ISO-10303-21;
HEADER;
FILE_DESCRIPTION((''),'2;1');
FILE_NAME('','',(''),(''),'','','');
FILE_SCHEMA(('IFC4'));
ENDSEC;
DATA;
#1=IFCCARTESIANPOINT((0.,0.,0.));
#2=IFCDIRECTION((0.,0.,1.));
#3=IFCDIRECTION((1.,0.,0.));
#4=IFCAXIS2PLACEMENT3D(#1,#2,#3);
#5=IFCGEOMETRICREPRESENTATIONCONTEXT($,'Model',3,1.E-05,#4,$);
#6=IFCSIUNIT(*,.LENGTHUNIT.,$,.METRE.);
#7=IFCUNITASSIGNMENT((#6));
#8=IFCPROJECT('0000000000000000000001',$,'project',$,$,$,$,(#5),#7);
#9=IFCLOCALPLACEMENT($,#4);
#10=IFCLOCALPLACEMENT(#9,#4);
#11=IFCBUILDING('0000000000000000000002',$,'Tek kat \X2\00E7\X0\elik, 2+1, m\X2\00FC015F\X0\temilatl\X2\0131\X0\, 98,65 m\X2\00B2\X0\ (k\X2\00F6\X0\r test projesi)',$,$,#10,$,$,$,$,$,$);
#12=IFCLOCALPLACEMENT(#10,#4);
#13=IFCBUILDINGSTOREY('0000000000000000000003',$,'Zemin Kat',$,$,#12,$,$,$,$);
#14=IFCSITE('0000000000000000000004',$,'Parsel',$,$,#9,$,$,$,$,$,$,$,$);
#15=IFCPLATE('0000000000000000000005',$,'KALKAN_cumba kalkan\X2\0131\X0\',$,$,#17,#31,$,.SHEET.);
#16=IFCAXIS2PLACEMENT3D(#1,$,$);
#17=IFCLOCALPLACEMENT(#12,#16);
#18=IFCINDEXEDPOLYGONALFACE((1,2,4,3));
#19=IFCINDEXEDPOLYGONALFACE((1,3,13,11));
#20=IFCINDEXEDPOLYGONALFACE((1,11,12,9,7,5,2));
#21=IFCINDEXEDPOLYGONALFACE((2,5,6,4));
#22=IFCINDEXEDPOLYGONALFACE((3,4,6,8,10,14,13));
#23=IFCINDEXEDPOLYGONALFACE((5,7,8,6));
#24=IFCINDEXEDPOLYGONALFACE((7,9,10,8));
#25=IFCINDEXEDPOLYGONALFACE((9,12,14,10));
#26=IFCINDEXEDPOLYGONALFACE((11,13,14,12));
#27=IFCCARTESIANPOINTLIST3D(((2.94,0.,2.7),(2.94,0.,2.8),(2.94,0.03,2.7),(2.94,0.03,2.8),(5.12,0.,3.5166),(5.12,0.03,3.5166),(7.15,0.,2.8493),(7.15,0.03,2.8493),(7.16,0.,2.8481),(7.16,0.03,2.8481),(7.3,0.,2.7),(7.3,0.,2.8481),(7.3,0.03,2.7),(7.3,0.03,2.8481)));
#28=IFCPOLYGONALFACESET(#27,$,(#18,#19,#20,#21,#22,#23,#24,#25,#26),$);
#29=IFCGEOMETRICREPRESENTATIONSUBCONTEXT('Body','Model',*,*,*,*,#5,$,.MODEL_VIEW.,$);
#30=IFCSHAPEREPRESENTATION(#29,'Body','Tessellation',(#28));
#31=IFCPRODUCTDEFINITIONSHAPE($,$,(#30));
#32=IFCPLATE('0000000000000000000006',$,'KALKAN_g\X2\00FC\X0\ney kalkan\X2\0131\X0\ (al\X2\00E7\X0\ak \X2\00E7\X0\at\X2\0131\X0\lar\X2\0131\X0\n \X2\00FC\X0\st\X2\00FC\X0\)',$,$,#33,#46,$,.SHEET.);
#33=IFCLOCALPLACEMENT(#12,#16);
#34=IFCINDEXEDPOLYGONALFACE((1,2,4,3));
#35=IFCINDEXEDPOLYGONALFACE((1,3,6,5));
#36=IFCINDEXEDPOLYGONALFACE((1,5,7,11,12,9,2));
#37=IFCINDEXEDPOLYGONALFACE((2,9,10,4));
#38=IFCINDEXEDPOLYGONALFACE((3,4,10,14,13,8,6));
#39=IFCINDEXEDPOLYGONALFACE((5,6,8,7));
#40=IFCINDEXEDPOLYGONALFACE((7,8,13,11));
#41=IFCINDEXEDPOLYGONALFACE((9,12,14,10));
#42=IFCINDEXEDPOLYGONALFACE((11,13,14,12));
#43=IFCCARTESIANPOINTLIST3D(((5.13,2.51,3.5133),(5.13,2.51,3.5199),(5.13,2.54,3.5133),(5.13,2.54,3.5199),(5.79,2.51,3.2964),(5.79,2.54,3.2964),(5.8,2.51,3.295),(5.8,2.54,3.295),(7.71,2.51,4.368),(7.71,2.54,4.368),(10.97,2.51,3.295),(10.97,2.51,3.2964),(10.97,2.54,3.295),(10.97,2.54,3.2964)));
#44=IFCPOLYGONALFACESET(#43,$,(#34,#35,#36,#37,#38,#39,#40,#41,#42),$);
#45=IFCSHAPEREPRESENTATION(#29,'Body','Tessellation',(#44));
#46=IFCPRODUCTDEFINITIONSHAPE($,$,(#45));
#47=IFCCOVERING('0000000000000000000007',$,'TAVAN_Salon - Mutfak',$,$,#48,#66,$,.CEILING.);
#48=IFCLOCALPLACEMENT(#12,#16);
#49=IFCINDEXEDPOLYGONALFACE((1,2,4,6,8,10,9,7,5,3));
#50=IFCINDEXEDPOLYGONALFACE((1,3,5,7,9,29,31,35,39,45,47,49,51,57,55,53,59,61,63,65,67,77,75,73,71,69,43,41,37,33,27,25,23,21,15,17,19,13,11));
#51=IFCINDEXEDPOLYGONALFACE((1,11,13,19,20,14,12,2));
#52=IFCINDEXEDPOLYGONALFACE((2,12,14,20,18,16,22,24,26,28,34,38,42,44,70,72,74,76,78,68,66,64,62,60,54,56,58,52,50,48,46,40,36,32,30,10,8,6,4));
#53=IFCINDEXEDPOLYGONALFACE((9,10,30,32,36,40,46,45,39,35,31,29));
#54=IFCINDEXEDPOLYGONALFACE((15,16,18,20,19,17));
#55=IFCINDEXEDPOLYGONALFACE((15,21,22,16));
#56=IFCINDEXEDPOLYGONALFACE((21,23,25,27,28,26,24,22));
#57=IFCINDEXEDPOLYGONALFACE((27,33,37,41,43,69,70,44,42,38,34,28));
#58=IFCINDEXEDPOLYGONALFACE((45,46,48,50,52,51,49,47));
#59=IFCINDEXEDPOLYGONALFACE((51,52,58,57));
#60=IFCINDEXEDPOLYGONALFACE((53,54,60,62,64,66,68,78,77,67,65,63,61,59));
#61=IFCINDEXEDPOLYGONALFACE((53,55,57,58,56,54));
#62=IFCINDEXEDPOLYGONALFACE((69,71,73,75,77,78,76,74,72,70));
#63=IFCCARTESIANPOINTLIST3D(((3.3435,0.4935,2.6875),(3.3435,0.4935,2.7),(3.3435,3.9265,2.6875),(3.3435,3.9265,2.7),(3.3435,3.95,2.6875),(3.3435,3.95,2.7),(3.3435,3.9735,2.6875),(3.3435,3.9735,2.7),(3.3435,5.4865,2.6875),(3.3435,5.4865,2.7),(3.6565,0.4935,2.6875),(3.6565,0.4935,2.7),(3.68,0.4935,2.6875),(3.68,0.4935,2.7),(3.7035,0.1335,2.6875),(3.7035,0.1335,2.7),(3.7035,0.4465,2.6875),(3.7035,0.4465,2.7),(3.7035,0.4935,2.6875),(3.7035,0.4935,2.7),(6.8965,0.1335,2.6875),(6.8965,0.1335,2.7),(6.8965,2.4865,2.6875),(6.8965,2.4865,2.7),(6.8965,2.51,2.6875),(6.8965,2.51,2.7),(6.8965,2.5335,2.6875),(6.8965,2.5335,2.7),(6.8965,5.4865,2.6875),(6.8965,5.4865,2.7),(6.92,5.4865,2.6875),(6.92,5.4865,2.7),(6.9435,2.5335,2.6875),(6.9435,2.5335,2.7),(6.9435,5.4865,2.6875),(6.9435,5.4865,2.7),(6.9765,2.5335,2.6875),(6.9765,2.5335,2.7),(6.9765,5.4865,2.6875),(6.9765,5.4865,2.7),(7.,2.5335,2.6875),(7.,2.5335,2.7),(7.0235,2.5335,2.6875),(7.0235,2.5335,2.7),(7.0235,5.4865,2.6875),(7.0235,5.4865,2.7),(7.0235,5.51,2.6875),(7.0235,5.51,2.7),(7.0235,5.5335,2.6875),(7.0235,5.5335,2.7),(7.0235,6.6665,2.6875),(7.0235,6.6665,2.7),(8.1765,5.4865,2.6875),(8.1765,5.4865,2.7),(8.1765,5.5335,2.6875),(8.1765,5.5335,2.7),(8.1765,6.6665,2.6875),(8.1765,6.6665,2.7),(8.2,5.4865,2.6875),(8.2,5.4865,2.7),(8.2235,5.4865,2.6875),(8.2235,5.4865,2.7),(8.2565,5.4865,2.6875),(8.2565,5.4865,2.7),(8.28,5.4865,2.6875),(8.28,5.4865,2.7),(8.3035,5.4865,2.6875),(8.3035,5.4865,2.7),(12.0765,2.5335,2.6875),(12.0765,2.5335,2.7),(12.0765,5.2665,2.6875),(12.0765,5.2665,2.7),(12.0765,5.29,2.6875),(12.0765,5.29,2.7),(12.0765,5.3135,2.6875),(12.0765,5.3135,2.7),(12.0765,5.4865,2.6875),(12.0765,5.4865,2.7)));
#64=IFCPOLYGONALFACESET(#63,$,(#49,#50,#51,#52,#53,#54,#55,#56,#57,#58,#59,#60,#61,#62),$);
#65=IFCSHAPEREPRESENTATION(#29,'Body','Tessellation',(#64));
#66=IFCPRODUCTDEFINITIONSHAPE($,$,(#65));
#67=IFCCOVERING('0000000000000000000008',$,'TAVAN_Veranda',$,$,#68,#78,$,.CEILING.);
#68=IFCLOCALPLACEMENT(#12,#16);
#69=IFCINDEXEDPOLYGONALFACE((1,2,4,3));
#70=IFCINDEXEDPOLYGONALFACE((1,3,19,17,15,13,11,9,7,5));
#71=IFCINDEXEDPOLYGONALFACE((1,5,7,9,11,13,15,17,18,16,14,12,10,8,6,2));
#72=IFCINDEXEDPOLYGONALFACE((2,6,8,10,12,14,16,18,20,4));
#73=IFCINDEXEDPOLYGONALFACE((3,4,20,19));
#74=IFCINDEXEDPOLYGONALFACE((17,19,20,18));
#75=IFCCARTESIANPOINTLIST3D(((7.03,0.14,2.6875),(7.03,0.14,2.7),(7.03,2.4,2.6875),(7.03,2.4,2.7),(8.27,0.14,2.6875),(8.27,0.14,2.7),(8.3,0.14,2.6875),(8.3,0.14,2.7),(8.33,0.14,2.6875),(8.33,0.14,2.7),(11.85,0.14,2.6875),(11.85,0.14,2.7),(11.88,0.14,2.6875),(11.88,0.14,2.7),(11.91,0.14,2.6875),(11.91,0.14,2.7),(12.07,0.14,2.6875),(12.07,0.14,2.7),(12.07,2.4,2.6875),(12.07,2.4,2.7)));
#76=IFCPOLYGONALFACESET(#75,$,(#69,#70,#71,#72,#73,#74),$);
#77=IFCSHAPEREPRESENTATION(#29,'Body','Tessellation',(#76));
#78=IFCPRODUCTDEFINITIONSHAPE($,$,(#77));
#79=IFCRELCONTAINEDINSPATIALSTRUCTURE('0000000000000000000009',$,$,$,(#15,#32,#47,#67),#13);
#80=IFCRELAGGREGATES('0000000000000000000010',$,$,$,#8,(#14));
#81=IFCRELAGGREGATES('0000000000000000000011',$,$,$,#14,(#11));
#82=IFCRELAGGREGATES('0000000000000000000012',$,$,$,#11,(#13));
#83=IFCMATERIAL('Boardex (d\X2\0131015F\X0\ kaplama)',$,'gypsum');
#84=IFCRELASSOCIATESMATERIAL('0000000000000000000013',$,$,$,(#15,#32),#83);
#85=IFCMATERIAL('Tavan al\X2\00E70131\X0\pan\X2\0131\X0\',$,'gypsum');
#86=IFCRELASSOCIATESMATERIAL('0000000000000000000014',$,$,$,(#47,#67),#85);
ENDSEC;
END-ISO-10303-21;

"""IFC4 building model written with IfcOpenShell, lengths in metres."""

from ifc_helpers import new_model, si_unit, frame, origin_with_axes, place, context, subcontext, project, spatial, line, indexed_curve, outline, extrude, material, element, save


model = new_model("IFC4")

# Units and contexts
model_context = context("Model", 3, precision=1e-05, world=origin_with_axes())
body_context = subcontext(model_context, "Body", "Model", "MODEL_VIEW")
ifc_project = project(units=[si_unit("LENGTHUNIT", "METRE")], contexts=[model_context])

# Site, building, storey
site_placement = place(None, origin_with_axes())
site = spatial("IfcSite", under=ifc_project, at=site_placement, Name="Parsel")
building_placement = place(site_placement, origin_with_axes())
building = spatial("IfcBuilding", under=site, at=building_placement, Name="Tek kat çelik, 2+1, müştemilatlı, 98,65 m² (kör test projesi)")
storey_placement = place(building_placement, origin_with_axes())
storey = spatial("IfcBuildingStorey", under=building, at=storey_placement, Name="Zemin Kat")

# Plates
ifc_material_1 = material(Name="Boardex (dış kaplama)", Category="gypsum")
plate_1_placement = place(storey_placement, origin_with_axes())
element("IfcPlate", 1, at=plate_1_placement, inside=storey, material=ifc_material_1, Name="KALKAN_cumba kalkanı", PredefinedType="SHEET", context=body_context, shape_type="SweptSolid", body=[
    extrude(outline(indexed_curve([(2.94, 2.8), (5.12, 3.5166), (7.15, 2.8493), (7.16, 2.8481), (7.3, 2.8481), (7.3, 2.7), (2.94, 2.7)], segments=[line(1, 2, 3, 4, 5, 6, 7, 1)])), frame((0.0, 0.03, 0.0), z_axis=(0.0, -1.0, 0.0), x_axis=(1.0, 0.0, 0.0)), (0.0, 0.0, 1.0), 0.03),
])
plate_2_placement = place(storey_placement, origin_with_axes())
element("IfcPlate", 2, at=plate_2_placement, inside=storey, material=ifc_material_1, Name="KALKAN_güney kalkanı (alçak çatıların üstü)", PredefinedType="SHEET", context=body_context, shape_type="SweptSolid", body=[
    extrude(outline(indexed_curve([(5.13, 3.5199), (7.71, 4.368), (10.97, 3.2964), (10.97, 3.295), (5.8, 3.295), (5.79, 3.2964), (5.13, 3.5133)], segments=[line(1, 2, 3, 4, 5, 6, 7, 1)])), frame((0.0, 2.54, 0.0), z_axis=(0.0, -1.0, 0.0), x_axis=(1.0, 0.0, 0.0)), (0.0, 0.0, 1.0), 0.03),
])

# Coverings
ifc_material_2 = material(Name="Tavan alçıpanı", Category="gypsum")
covering_1_placement = place(storey_placement, origin_with_axes())
element("IfcCovering", 3, at=covering_1_placement, inside=storey, material=ifc_material_2, Name="TAVAN_Salon - Mutfak", PredefinedType="CEILING", context=body_context, shape_type="SweptSolid", body=[
    extrude(outline(indexed_curve([(6.9435, 5.4865), (6.9765, 5.4865), (7.0235, 5.4865), (7.0235, 5.51), (7.0235, 5.5335), (7.0235, 6.6665), (8.1765, 6.6665), (8.1765, 5.5335), (8.1765, 5.4865), (8.2, 5.4865), (8.2235, 5.4865), (8.2565, 5.4865), (8.28, 5.4865), (8.3035, 5.4865), (12.0765, 5.4865), (12.0765, 5.3135), (12.0765, 5.29), (12.0765, 5.2665), (12.0765, 2.5335), (7.0235, 2.5335), (7.0, 2.5335), (6.9765, 2.5335), (6.9435, 2.5335), (6.8965, 2.5335), (6.8965, 2.51), (6.8965, 2.4865), (6.8965, 0.1335), (3.7035, 0.1335), (3.7035, 0.4465), (3.7035, 0.4935), (3.68, 0.4935), (3.6565, 0.4935), (3.3435, 0.4935), (3.3435, 3.9265), (3.3435, 3.95), (3.3435, 3.9735), (3.3435, 5.4865), (6.8965, 5.4865), (6.92, 5.4865)], segments=[line(1, 2, 3, 4, 5, 6, 7, 8, 9, 10, 11, 12, 13, 14, 15, 16, 17, 18, 19, 20, 21, 22, 23, 24, 25, 26, 27, 28, 29, 30, 31, 32, 33, 34, 35, 36, 37, 38, 39, 1)])), frame((0.0, 0.0, 2.6875), z_axis=(0.0, 0.0, 1.0), x_axis=(1.0, 0.0, 0.0)), (0.0, 0.0, 1.0), 0.0125),
])
covering_2_placement = place(storey_placement, origin_with_axes())
element("IfcCovering", 4, at=covering_2_placement, inside=storey, material=ifc_material_2, Name="TAVAN_Veranda", PredefinedType="CEILING", context=body_context, shape_type="SweptSolid", body=[
    extrude(outline(indexed_curve([(12.07, 2.4), (12.07, 0.14), (11.91, 0.14), (11.88, 0.14), (11.85, 0.14), (8.33, 0.14), (8.3, 0.14), (8.27, 0.14), (7.03, 0.14), (7.03, 2.4)], segments=[line(1, 2, 3, 4, 5, 6, 7, 8, 9, 10, 1)])), frame((0.0, 0.0, 2.6875), z_axis=(0.0, 0.0, 1.0), x_axis=(1.0, 0.0, 0.0)), (0.0, 0.0, 1.0), 0.0125),
])

save(model, "model.ifc")
